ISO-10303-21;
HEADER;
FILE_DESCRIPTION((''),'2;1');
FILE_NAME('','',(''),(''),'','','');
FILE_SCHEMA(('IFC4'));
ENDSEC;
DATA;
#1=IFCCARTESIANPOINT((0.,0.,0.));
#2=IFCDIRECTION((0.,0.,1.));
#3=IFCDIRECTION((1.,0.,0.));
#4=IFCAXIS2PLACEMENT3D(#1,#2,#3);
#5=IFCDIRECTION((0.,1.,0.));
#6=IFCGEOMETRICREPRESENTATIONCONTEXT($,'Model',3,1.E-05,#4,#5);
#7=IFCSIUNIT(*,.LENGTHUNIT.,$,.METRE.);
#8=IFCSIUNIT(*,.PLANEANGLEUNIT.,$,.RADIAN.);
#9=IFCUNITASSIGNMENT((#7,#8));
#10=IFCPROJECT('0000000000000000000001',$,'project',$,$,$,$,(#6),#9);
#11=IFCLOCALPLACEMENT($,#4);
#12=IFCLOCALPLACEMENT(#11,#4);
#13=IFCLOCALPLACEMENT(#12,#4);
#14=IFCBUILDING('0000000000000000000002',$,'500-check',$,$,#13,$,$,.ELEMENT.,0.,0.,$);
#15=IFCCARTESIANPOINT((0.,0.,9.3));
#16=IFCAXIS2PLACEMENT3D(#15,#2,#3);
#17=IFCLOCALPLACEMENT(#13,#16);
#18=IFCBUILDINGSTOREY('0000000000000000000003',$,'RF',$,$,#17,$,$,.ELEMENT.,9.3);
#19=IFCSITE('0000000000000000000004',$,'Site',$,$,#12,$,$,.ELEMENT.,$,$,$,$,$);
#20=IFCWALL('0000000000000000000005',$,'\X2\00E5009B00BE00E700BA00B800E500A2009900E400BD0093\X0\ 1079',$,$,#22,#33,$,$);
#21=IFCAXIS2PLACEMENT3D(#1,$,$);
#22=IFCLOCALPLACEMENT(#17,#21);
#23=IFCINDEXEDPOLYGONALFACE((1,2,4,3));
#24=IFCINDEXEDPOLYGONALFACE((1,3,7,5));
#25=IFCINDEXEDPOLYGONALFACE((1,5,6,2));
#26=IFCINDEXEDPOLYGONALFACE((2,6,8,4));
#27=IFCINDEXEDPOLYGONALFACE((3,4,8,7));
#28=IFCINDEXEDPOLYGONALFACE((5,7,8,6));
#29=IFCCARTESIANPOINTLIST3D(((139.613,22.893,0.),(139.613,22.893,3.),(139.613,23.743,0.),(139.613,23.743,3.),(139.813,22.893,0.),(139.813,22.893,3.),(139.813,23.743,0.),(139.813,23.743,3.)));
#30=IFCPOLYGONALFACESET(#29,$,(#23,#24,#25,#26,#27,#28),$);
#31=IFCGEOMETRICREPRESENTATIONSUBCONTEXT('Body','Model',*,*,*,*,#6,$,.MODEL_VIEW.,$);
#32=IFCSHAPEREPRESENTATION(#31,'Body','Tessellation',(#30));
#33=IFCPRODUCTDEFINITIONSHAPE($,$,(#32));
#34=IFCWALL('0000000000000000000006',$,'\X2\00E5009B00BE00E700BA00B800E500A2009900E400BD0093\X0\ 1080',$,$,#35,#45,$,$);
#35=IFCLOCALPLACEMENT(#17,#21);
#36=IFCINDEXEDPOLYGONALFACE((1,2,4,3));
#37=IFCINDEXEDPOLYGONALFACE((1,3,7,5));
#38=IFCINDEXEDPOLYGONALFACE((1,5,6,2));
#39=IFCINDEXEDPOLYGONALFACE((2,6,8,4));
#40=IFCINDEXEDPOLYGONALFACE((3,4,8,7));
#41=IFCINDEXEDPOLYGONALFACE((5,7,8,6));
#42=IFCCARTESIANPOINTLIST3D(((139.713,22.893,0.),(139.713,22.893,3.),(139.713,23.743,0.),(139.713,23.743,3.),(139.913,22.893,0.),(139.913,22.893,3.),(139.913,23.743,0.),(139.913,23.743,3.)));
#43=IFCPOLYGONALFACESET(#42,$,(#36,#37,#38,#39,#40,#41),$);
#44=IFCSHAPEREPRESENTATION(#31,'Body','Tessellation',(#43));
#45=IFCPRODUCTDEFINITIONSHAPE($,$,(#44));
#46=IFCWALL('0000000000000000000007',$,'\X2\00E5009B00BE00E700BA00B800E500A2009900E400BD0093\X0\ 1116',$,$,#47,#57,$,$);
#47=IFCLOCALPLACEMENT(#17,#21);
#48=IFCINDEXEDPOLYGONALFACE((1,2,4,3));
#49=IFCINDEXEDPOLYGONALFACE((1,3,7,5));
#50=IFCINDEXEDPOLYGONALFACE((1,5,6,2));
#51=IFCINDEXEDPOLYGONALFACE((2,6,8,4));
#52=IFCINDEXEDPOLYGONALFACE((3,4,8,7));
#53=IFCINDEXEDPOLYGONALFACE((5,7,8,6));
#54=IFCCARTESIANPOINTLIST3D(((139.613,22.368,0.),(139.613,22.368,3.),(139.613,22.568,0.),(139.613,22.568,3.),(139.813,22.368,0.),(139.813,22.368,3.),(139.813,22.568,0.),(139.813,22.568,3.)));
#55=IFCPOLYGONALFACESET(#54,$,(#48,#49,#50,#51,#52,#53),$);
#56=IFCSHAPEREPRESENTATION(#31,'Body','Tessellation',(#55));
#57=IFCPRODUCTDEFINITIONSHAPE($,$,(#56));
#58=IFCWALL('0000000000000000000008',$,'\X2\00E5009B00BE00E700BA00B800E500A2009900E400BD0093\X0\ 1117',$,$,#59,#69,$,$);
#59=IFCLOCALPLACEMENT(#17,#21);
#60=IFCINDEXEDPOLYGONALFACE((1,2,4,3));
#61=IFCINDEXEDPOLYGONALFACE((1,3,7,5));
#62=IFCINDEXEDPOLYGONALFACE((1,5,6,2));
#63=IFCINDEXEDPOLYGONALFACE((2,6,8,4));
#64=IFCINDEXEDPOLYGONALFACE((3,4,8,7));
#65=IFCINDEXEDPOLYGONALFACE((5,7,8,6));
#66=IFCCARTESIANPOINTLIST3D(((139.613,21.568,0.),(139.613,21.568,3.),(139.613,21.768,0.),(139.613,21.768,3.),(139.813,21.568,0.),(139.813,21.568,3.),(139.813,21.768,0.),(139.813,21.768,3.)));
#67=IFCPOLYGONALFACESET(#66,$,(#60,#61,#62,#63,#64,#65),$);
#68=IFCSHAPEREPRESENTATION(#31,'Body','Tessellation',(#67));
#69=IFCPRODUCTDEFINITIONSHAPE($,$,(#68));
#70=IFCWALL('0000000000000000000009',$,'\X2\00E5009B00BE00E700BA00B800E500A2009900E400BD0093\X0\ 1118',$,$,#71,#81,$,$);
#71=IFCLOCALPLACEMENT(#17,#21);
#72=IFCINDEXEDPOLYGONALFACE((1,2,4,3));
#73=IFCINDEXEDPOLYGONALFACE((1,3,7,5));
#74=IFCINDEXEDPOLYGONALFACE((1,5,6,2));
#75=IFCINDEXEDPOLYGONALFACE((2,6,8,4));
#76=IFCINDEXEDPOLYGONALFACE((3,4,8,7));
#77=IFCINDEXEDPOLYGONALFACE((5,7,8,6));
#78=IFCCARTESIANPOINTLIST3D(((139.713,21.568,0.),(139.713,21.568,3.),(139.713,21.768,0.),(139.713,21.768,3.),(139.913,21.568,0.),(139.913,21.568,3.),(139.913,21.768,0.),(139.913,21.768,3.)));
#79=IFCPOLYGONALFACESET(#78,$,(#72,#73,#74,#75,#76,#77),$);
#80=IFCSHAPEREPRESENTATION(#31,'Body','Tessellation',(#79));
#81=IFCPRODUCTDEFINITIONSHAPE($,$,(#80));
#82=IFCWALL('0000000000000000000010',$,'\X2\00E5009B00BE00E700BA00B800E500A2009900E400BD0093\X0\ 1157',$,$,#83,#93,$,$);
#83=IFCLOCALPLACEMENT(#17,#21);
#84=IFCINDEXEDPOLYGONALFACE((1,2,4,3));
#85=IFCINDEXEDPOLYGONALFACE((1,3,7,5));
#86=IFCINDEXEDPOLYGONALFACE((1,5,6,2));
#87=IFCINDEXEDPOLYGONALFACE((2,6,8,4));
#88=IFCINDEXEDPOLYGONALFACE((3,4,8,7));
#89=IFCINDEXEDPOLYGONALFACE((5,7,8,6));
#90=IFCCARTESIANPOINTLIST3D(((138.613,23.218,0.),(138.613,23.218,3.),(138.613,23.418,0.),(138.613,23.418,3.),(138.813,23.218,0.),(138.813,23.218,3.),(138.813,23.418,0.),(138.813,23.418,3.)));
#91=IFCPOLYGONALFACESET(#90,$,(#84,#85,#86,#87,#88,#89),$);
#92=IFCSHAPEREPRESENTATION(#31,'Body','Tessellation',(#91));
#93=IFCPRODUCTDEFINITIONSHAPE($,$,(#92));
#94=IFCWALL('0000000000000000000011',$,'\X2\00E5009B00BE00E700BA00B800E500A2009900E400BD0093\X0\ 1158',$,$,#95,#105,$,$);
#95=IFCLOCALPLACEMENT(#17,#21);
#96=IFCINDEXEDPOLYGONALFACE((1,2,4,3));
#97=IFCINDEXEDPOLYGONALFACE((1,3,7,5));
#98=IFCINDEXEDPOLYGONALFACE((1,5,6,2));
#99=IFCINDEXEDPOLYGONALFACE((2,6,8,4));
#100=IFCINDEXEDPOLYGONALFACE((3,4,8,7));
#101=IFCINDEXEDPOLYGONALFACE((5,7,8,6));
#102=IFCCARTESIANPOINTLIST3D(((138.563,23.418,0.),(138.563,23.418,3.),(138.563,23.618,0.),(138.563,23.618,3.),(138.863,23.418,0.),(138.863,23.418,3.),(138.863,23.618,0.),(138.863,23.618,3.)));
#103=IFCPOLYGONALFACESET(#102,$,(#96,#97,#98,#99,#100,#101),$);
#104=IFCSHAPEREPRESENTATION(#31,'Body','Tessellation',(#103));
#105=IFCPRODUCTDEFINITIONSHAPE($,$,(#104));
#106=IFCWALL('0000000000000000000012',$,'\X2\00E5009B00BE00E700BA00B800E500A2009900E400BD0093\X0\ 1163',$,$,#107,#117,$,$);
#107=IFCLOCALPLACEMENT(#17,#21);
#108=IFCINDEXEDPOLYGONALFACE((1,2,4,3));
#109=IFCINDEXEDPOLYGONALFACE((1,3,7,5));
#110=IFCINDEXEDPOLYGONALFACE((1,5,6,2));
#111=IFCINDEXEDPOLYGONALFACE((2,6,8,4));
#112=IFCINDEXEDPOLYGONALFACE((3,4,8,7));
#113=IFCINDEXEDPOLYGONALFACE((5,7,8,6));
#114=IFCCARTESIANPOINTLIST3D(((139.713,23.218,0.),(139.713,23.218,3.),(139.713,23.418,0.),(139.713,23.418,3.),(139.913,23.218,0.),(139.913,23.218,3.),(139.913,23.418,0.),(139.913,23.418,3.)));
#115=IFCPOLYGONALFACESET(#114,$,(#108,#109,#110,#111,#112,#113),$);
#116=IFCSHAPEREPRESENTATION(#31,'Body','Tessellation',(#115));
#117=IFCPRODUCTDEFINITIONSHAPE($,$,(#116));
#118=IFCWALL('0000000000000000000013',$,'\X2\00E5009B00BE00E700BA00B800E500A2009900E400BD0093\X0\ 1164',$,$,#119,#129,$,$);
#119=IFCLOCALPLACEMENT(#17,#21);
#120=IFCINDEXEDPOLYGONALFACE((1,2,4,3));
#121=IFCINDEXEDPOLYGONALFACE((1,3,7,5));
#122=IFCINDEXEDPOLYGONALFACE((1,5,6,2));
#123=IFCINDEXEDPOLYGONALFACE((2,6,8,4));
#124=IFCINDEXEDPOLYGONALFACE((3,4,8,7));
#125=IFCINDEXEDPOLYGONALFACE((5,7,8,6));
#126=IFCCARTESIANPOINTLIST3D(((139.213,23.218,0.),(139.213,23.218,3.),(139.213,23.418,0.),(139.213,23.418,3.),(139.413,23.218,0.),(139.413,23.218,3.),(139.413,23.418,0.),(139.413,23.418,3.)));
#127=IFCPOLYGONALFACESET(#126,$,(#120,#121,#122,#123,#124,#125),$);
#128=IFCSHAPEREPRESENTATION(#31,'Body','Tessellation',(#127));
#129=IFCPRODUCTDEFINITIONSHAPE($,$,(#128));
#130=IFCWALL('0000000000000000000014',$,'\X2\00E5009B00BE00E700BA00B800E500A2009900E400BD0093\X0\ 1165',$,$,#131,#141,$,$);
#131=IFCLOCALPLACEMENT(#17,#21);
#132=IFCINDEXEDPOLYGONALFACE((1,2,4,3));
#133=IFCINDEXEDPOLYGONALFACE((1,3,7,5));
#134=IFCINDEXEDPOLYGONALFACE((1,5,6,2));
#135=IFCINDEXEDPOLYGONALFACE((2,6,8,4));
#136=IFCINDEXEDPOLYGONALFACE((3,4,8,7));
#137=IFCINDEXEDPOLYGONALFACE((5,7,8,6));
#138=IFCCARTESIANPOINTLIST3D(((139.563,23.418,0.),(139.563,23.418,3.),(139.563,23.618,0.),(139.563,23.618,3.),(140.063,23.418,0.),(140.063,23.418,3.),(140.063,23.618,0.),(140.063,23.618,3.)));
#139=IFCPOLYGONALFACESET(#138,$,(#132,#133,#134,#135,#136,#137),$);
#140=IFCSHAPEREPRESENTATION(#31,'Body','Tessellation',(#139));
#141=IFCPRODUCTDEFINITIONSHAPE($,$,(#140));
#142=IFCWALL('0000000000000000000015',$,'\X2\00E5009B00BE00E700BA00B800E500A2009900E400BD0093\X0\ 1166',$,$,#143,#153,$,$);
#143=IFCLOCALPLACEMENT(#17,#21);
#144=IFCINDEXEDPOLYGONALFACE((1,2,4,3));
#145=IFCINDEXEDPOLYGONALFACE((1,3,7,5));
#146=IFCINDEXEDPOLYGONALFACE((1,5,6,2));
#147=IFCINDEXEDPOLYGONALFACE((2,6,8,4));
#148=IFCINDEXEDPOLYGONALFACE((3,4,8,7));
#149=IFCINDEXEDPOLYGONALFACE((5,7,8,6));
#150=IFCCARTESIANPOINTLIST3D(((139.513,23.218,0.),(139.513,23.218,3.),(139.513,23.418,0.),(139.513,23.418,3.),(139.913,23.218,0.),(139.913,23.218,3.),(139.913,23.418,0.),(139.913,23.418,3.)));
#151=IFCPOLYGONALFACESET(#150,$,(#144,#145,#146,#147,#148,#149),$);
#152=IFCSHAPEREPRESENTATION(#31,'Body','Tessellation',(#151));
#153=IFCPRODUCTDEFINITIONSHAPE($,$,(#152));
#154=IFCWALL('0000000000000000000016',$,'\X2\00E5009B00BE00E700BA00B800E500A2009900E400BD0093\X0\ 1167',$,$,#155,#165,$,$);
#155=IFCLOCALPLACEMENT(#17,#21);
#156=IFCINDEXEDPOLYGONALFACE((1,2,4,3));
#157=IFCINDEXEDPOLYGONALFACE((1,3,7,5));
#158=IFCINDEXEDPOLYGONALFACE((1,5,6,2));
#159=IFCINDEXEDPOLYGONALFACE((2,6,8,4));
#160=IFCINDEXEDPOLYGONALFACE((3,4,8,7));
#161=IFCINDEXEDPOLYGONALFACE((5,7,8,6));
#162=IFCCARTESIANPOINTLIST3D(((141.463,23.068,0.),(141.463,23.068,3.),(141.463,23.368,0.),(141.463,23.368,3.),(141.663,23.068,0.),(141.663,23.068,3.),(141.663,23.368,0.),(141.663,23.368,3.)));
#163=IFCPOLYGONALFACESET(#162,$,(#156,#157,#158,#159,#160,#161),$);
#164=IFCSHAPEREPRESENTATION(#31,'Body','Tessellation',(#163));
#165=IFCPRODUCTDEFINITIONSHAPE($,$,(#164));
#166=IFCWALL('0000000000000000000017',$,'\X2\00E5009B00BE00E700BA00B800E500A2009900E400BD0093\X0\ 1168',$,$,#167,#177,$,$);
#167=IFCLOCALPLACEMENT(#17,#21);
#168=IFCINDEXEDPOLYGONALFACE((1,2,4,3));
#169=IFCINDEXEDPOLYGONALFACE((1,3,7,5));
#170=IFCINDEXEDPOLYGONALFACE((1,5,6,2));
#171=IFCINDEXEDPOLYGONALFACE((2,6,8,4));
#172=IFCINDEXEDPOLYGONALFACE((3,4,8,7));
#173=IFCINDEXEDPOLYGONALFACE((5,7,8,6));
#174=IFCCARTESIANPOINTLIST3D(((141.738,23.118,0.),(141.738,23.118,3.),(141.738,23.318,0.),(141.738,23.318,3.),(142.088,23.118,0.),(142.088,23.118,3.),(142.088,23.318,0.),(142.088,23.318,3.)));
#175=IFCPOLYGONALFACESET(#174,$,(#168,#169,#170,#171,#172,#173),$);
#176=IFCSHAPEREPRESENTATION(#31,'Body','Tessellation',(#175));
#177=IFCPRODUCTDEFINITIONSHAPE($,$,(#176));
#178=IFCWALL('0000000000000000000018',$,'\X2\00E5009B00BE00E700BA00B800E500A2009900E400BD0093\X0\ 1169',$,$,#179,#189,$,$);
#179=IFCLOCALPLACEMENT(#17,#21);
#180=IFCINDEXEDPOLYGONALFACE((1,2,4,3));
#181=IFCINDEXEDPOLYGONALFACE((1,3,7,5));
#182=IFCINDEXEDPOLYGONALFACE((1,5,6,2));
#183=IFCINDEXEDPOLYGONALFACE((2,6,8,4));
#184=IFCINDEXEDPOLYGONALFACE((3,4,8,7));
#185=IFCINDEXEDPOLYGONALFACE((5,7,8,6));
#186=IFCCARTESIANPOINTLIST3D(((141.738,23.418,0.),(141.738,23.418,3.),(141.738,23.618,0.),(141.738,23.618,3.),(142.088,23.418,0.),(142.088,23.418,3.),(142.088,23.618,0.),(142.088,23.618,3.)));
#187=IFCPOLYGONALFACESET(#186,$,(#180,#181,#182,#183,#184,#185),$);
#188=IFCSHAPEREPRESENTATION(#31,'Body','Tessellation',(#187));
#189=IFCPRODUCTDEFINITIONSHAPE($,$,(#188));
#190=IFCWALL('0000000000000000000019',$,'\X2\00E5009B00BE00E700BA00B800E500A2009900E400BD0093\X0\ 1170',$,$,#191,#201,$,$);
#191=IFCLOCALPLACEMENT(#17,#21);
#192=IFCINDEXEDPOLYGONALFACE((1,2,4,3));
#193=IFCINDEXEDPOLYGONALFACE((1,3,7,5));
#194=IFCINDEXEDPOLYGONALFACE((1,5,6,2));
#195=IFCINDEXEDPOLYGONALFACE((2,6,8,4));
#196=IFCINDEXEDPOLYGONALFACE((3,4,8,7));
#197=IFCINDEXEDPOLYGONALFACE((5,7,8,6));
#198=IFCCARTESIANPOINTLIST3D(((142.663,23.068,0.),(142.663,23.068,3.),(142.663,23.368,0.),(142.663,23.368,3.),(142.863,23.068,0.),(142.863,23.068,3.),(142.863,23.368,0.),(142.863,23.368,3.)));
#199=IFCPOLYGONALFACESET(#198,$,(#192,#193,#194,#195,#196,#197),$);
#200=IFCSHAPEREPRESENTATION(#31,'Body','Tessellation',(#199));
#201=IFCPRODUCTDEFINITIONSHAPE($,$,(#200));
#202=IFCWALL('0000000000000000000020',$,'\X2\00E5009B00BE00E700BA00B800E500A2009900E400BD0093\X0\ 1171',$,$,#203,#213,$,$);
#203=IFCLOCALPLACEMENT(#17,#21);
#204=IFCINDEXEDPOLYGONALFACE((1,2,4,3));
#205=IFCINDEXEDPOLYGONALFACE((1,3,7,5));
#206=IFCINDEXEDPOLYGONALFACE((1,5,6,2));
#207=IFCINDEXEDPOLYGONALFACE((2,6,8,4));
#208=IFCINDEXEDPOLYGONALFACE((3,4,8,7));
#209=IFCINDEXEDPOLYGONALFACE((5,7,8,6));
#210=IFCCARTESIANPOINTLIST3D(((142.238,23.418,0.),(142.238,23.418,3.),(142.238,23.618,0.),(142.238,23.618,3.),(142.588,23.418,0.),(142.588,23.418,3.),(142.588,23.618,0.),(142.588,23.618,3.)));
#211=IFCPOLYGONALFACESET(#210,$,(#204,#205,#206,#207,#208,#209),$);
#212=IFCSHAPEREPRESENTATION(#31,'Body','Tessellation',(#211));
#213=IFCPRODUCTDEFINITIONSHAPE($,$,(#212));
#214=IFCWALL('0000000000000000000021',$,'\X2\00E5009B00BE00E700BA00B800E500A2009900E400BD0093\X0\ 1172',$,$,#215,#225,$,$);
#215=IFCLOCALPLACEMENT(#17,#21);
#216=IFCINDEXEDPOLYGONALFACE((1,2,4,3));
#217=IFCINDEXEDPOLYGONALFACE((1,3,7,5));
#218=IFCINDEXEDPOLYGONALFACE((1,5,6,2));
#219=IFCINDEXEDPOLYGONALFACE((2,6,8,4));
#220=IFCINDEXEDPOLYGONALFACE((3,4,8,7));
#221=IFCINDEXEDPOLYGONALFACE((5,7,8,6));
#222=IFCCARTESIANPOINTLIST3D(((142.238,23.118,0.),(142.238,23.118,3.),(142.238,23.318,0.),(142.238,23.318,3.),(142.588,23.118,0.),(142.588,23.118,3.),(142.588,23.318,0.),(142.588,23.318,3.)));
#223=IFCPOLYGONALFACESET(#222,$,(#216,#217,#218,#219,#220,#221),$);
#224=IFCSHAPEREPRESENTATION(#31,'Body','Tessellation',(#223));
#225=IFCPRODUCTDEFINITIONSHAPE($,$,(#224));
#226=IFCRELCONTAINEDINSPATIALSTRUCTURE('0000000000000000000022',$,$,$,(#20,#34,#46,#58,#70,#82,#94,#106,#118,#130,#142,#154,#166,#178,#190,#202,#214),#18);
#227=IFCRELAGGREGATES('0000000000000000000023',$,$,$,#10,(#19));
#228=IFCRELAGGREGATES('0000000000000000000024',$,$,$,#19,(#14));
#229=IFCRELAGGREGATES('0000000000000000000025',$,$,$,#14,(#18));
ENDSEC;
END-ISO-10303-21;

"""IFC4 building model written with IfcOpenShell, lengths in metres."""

from ifc_helpers import new_model, si_unit, direction, frame, frame_2d, origin_with_axes, place, context, subcontext, project, spatial, rectangle, extrude, element, save


model = new_model("IFC4")

# Units and contexts
model_context = context("Model", 3, precision=1e-05, world=origin_with_axes(), true_north=direction((0.0, 1.0, 0.0)))
body_context = subcontext(model_context, "Body", "Model", "MODEL_VIEW")
ifc_project = project(units=[si_unit("LENGTHUNIT", "METRE"), si_unit("PLANEANGLEUNIT", "RADIAN")], contexts=[model_context])

# Site, building, storey
placement = place(None, origin_with_axes())
site_placement = place(placement, origin_with_axes())
site = spatial("IfcSite", under=ifc_project, at=site_placement, Name="Site", CompositionType="ELEMENT")
building_placement = place(site_placement, origin_with_axes())
building = spatial("IfcBuilding", under=site, at=building_placement, Name="500-check", CompositionType="ELEMENT", ElevationOfRefHeight=0.0, ElevationOfTerrain=0.0)
storey_placement = place(building_placement, frame((0.0, 0.0, 9.3), z_axis=(0.0, 0.0, 1.0), x_axis=(1.0, 0.0, 0.0)))
storey = spatial("IfcBuildingStorey", under=building, at=storey_placement, Name="RF", CompositionType="ELEMENT", Elevation=9.3)

# Walls
for number, where, z_axis, x_axis, name in (
    (1, (139.713, 23.318, 0.0), (0.0, 0.0, 1.0), (0.0, -1.0, 0.0), "å\u009b¾çº¸å¢\u0099ä½\u0093 1079"),
    (2, (139.813, 23.318, 0.0), (0.0, 0.0, 1.0), (0.0, -1.0, 0.0), "å\u009b¾çº¸å¢\u0099ä½\u0093 1080"),
):
    element("IfcWall", number, at=place(storey_placement, frame(where, z_axis=z_axis, x_axis=x_axis)), inside=storey, Name=name, context=body_context, shape_type="SweptSolid", body=[
        extrude(rectangle(XDim=0.85, YDim=0.2, at=frame_2d((0.0, 0.0), x_axis=(1.0, 0.0, 0.0))), frame((0.0, 0.0, 0.0), z_axis=(0.0, 0.0, 1.0)), (0.0, 0.0, 1.0), 3.0),
    ])
for number, where, z_axis, x_axis, name in (
    (3, (139.713, 22.468, 0.0), (0.0, 0.0, 1.0), (1.0, 0.0, 0.0), "å\u009b¾çº¸å¢\u0099ä½\u0093 1116"),
    (4, (139.713, 21.668, 0.0), (0.0, 0.0, 1.0), (1.0, 0.0, 0.0), "å\u009b¾çº¸å¢\u0099ä½\u0093 1117"),
    (5, (139.813, 21.668, 0.0), (0.0, 0.0, 1.0), (0.0, -1.0, 0.0), "å\u009b¾çº¸å¢\u0099ä½\u0093 1118"),
    (6, (138.713, 23.318, 0.0), (0.0, 0.0, 1.0), (-1.0, 0.0, 0.0), "å\u009b¾çº¸å¢\u0099ä½\u0093 1157"),
):
    element("IfcWall", number, at=place(storey_placement, frame(where, z_axis=z_axis, x_axis=x_axis)), inside=storey, Name=name, context=body_context, shape_type="SweptSolid", body=[
        extrude(rectangle(XDim=0.2, YDim=0.2, at=frame_2d((0.0, 0.0), x_axis=(1.0, 0.0, 0.0))), frame((0.0, 0.0, 0.0), z_axis=(0.0, 0.0, 1.0)), (0.0, 0.0, 1.0), 3.0),
    ])
wall_1_placement = place(storey_placement, frame((138.713, 23.518, 0.0), z_axis=(0.0, 0.0, 1.0), x_axis=(-1.0, 0.0, 0.0)))
element("IfcWall", 7, at=wall_1_placement, inside=storey, Name="å\u009b¾çº¸å¢\u0099ä½\u0093 1158", context=body_context, shape_type="SweptSolid", body=[
    extrude(rectangle(XDim=0.3, YDim=0.2, at=frame_2d((0.0, 0.0), x_axis=(1.0, 0.0, 0.0))), frame((0.0, 0.0, 0.0), z_axis=(0.0, 0.0, 1.0)), (0.0, 0.0, 1.0), 3.0),
])
for number, where, z_axis, x_axis, name in (
    (8, (139.813, 23.318, 0.0), (0.0, 0.0, 1.0), (0.0, 1.0, 0.0), "å\u009b¾çº¸å¢\u0099ä½\u0093 1163"),
    (9, (139.313, 23.318, 0.0), (0.0, 0.0, 1.0), (0.0, 1.0, 0.0), "å\u009b¾çº¸å¢\u0099ä½\u0093 1164"),
):
    element("IfcWall", number, at=place(storey_placement, frame(where, z_axis=z_axis, x_axis=x_axis)), inside=storey, Name=name, context=body_context, shape_type="SweptSolid", body=[
        extrude(rectangle(XDim=0.2, YDim=0.2, at=frame_2d((0.0, 0.0), x_axis=(1.0, 0.0, 0.0))), frame((0.0, 0.0, 0.0), z_axis=(0.0, 0.0, 1.0)), (0.0, 0.0, 1.0), 3.0),
    ])
wall_2_placement = place(storey_placement, frame((139.813, 23.518, 0.0), z_axis=(0.0, 0.0, 1.0), x_axis=(-1.0, 0.0, 0.0)))
element("IfcWall", 10, at=wall_2_placement, inside=storey, Name="å\u009b¾çº¸å¢\u0099ä½\u0093 1165", context=body_context, shape_type="SweptSolid", body=[
    extrude(rectangle(XDim=0.5, YDim=0.2, at=frame_2d((0.0, 0.0), x_axis=(1.0, 0.0, 0.0))), frame((0.0, 0.0, 0.0), z_axis=(0.0, 0.0, 1.0)), (0.0, 0.0, 1.0), 3.0),
])
wall_3_placement = place(storey_placement, frame((139.713, 23.318, 0.0), z_axis=(0.0, 0.0, 1.0), x_axis=(-1.0, 0.0, 0.0)))
element("IfcWall", 11, at=wall_3_placement, inside=storey, Name="å\u009b¾çº¸å¢\u0099ä½\u0093 1166", context=body_context, shape_type="SweptSolid", body=[
    extrude(rectangle(XDim=0.4, YDim=0.2, at=frame_2d((0.0, 0.0), x_axis=(1.0, 0.0, 0.0))), frame((0.0, 0.0, 0.0), z_axis=(0.0, 0.0, 1.0)), (0.0, 0.0, 1.0), 3.0),
])
wall_4_placement = place(storey_placement, frame((141.563, 23.218, 0.0), z_axis=(0.0, 0.0, 1.0), x_axis=(0.0, 1.0, 0.0)))
element("IfcWall", 12, at=wall_4_placement, inside=storey, Name="å\u009b¾çº¸å¢\u0099ä½\u0093 1167", context=body_context, shape_type="SweptSolid", body=[
    extrude(rectangle(XDim=0.3, YDim=0.2, at=frame_2d((0.0, 0.0), x_axis=(1.0, 0.0, 0.0))), frame((0.0, 0.0, 0.0), z_axis=(0.0, 0.0, 1.0)), (0.0, 0.0, 1.0), 3.0),
])
for number, where, z_axis, x_axis, name in (
    (13, (141.913, 23.218, 0.0), (0.0, 0.0, 1.0), (-1.0, 0.0, 0.0), "å\u009b¾çº¸å¢\u0099ä½\u0093 1168"),
    (14, (141.913, 23.518, 0.0), (0.0, 0.0, 1.0), (-1.0, 0.0, 0.0), "å\u009b¾çº¸å¢\u0099ä½\u0093 1169"),
):
    element("IfcWall", number, at=place(storey_placement, frame(where, z_axis=z_axis, x_axis=x_axis)), inside=storey, Name=name, context=body_context, shape_type="SweptSolid", body=[
        extrude(rectangle(XDim=0.35, YDim=0.2, at=frame_2d((0.0, 0.0), x_axis=(1.0, 0.0, 0.0))), frame((0.0, 0.0, 0.0), z_axis=(0.0, 0.0, 1.0)), (0.0, 0.0, 1.0), 3.0),
    ])
wall_5_placement = place(storey_placement, frame((142.763, 23.218, 0.0), z_axis=(0.0, 0.0, 1.0), x_axis=(0.0, 1.0, 0.0)))
element("IfcWall", 15, at=wall_5_placement, inside=storey, Name="å\u009b¾çº¸å¢\u0099ä½\u0093 1170", context=body_context, shape_type="SweptSolid", body=[
    extrude(rectangle(XDim=0.3, YDim=0.2, at=frame_2d((0.0, 0.0), x_axis=(1.0, 0.0, 0.0))), frame((0.0, 0.0, 0.0), z_axis=(0.0, 0.0, 1.0)), (0.0, 0.0, 1.0), 3.0),
])
for number, where, z_axis, x_axis, name in (
    (16, (142.413, 23.518, 0.0), (0.0, 0.0, 1.0), (1.0, 0.0, 0.0), "å\u009b¾çº¸å¢\u0099ä½\u0093 1171"),
    (17, (142.413, 23.218, 0.0), (0.0, 0.0, 1.0), (1.0, 0.0, 0.0), "å\u009b¾çº¸å¢\u0099ä½\u0093 1172"),
):
    element("IfcWall", number, at=place(storey_placement, frame(where, z_axis=z_axis, x_axis=x_axis)), inside=storey, Name=name, context=body_context, shape_type="SweptSolid", body=[
        extrude(rectangle(XDim=0.35, YDim=0.2, at=frame_2d((0.0, 0.0), x_axis=(1.0, 0.0, 0.0))), frame((0.0, 0.0, 0.0), z_axis=(0.0, 0.0, 1.0)), (0.0, 0.0, 1.0), 3.0),
    ])

save(model, "model.ifc")
